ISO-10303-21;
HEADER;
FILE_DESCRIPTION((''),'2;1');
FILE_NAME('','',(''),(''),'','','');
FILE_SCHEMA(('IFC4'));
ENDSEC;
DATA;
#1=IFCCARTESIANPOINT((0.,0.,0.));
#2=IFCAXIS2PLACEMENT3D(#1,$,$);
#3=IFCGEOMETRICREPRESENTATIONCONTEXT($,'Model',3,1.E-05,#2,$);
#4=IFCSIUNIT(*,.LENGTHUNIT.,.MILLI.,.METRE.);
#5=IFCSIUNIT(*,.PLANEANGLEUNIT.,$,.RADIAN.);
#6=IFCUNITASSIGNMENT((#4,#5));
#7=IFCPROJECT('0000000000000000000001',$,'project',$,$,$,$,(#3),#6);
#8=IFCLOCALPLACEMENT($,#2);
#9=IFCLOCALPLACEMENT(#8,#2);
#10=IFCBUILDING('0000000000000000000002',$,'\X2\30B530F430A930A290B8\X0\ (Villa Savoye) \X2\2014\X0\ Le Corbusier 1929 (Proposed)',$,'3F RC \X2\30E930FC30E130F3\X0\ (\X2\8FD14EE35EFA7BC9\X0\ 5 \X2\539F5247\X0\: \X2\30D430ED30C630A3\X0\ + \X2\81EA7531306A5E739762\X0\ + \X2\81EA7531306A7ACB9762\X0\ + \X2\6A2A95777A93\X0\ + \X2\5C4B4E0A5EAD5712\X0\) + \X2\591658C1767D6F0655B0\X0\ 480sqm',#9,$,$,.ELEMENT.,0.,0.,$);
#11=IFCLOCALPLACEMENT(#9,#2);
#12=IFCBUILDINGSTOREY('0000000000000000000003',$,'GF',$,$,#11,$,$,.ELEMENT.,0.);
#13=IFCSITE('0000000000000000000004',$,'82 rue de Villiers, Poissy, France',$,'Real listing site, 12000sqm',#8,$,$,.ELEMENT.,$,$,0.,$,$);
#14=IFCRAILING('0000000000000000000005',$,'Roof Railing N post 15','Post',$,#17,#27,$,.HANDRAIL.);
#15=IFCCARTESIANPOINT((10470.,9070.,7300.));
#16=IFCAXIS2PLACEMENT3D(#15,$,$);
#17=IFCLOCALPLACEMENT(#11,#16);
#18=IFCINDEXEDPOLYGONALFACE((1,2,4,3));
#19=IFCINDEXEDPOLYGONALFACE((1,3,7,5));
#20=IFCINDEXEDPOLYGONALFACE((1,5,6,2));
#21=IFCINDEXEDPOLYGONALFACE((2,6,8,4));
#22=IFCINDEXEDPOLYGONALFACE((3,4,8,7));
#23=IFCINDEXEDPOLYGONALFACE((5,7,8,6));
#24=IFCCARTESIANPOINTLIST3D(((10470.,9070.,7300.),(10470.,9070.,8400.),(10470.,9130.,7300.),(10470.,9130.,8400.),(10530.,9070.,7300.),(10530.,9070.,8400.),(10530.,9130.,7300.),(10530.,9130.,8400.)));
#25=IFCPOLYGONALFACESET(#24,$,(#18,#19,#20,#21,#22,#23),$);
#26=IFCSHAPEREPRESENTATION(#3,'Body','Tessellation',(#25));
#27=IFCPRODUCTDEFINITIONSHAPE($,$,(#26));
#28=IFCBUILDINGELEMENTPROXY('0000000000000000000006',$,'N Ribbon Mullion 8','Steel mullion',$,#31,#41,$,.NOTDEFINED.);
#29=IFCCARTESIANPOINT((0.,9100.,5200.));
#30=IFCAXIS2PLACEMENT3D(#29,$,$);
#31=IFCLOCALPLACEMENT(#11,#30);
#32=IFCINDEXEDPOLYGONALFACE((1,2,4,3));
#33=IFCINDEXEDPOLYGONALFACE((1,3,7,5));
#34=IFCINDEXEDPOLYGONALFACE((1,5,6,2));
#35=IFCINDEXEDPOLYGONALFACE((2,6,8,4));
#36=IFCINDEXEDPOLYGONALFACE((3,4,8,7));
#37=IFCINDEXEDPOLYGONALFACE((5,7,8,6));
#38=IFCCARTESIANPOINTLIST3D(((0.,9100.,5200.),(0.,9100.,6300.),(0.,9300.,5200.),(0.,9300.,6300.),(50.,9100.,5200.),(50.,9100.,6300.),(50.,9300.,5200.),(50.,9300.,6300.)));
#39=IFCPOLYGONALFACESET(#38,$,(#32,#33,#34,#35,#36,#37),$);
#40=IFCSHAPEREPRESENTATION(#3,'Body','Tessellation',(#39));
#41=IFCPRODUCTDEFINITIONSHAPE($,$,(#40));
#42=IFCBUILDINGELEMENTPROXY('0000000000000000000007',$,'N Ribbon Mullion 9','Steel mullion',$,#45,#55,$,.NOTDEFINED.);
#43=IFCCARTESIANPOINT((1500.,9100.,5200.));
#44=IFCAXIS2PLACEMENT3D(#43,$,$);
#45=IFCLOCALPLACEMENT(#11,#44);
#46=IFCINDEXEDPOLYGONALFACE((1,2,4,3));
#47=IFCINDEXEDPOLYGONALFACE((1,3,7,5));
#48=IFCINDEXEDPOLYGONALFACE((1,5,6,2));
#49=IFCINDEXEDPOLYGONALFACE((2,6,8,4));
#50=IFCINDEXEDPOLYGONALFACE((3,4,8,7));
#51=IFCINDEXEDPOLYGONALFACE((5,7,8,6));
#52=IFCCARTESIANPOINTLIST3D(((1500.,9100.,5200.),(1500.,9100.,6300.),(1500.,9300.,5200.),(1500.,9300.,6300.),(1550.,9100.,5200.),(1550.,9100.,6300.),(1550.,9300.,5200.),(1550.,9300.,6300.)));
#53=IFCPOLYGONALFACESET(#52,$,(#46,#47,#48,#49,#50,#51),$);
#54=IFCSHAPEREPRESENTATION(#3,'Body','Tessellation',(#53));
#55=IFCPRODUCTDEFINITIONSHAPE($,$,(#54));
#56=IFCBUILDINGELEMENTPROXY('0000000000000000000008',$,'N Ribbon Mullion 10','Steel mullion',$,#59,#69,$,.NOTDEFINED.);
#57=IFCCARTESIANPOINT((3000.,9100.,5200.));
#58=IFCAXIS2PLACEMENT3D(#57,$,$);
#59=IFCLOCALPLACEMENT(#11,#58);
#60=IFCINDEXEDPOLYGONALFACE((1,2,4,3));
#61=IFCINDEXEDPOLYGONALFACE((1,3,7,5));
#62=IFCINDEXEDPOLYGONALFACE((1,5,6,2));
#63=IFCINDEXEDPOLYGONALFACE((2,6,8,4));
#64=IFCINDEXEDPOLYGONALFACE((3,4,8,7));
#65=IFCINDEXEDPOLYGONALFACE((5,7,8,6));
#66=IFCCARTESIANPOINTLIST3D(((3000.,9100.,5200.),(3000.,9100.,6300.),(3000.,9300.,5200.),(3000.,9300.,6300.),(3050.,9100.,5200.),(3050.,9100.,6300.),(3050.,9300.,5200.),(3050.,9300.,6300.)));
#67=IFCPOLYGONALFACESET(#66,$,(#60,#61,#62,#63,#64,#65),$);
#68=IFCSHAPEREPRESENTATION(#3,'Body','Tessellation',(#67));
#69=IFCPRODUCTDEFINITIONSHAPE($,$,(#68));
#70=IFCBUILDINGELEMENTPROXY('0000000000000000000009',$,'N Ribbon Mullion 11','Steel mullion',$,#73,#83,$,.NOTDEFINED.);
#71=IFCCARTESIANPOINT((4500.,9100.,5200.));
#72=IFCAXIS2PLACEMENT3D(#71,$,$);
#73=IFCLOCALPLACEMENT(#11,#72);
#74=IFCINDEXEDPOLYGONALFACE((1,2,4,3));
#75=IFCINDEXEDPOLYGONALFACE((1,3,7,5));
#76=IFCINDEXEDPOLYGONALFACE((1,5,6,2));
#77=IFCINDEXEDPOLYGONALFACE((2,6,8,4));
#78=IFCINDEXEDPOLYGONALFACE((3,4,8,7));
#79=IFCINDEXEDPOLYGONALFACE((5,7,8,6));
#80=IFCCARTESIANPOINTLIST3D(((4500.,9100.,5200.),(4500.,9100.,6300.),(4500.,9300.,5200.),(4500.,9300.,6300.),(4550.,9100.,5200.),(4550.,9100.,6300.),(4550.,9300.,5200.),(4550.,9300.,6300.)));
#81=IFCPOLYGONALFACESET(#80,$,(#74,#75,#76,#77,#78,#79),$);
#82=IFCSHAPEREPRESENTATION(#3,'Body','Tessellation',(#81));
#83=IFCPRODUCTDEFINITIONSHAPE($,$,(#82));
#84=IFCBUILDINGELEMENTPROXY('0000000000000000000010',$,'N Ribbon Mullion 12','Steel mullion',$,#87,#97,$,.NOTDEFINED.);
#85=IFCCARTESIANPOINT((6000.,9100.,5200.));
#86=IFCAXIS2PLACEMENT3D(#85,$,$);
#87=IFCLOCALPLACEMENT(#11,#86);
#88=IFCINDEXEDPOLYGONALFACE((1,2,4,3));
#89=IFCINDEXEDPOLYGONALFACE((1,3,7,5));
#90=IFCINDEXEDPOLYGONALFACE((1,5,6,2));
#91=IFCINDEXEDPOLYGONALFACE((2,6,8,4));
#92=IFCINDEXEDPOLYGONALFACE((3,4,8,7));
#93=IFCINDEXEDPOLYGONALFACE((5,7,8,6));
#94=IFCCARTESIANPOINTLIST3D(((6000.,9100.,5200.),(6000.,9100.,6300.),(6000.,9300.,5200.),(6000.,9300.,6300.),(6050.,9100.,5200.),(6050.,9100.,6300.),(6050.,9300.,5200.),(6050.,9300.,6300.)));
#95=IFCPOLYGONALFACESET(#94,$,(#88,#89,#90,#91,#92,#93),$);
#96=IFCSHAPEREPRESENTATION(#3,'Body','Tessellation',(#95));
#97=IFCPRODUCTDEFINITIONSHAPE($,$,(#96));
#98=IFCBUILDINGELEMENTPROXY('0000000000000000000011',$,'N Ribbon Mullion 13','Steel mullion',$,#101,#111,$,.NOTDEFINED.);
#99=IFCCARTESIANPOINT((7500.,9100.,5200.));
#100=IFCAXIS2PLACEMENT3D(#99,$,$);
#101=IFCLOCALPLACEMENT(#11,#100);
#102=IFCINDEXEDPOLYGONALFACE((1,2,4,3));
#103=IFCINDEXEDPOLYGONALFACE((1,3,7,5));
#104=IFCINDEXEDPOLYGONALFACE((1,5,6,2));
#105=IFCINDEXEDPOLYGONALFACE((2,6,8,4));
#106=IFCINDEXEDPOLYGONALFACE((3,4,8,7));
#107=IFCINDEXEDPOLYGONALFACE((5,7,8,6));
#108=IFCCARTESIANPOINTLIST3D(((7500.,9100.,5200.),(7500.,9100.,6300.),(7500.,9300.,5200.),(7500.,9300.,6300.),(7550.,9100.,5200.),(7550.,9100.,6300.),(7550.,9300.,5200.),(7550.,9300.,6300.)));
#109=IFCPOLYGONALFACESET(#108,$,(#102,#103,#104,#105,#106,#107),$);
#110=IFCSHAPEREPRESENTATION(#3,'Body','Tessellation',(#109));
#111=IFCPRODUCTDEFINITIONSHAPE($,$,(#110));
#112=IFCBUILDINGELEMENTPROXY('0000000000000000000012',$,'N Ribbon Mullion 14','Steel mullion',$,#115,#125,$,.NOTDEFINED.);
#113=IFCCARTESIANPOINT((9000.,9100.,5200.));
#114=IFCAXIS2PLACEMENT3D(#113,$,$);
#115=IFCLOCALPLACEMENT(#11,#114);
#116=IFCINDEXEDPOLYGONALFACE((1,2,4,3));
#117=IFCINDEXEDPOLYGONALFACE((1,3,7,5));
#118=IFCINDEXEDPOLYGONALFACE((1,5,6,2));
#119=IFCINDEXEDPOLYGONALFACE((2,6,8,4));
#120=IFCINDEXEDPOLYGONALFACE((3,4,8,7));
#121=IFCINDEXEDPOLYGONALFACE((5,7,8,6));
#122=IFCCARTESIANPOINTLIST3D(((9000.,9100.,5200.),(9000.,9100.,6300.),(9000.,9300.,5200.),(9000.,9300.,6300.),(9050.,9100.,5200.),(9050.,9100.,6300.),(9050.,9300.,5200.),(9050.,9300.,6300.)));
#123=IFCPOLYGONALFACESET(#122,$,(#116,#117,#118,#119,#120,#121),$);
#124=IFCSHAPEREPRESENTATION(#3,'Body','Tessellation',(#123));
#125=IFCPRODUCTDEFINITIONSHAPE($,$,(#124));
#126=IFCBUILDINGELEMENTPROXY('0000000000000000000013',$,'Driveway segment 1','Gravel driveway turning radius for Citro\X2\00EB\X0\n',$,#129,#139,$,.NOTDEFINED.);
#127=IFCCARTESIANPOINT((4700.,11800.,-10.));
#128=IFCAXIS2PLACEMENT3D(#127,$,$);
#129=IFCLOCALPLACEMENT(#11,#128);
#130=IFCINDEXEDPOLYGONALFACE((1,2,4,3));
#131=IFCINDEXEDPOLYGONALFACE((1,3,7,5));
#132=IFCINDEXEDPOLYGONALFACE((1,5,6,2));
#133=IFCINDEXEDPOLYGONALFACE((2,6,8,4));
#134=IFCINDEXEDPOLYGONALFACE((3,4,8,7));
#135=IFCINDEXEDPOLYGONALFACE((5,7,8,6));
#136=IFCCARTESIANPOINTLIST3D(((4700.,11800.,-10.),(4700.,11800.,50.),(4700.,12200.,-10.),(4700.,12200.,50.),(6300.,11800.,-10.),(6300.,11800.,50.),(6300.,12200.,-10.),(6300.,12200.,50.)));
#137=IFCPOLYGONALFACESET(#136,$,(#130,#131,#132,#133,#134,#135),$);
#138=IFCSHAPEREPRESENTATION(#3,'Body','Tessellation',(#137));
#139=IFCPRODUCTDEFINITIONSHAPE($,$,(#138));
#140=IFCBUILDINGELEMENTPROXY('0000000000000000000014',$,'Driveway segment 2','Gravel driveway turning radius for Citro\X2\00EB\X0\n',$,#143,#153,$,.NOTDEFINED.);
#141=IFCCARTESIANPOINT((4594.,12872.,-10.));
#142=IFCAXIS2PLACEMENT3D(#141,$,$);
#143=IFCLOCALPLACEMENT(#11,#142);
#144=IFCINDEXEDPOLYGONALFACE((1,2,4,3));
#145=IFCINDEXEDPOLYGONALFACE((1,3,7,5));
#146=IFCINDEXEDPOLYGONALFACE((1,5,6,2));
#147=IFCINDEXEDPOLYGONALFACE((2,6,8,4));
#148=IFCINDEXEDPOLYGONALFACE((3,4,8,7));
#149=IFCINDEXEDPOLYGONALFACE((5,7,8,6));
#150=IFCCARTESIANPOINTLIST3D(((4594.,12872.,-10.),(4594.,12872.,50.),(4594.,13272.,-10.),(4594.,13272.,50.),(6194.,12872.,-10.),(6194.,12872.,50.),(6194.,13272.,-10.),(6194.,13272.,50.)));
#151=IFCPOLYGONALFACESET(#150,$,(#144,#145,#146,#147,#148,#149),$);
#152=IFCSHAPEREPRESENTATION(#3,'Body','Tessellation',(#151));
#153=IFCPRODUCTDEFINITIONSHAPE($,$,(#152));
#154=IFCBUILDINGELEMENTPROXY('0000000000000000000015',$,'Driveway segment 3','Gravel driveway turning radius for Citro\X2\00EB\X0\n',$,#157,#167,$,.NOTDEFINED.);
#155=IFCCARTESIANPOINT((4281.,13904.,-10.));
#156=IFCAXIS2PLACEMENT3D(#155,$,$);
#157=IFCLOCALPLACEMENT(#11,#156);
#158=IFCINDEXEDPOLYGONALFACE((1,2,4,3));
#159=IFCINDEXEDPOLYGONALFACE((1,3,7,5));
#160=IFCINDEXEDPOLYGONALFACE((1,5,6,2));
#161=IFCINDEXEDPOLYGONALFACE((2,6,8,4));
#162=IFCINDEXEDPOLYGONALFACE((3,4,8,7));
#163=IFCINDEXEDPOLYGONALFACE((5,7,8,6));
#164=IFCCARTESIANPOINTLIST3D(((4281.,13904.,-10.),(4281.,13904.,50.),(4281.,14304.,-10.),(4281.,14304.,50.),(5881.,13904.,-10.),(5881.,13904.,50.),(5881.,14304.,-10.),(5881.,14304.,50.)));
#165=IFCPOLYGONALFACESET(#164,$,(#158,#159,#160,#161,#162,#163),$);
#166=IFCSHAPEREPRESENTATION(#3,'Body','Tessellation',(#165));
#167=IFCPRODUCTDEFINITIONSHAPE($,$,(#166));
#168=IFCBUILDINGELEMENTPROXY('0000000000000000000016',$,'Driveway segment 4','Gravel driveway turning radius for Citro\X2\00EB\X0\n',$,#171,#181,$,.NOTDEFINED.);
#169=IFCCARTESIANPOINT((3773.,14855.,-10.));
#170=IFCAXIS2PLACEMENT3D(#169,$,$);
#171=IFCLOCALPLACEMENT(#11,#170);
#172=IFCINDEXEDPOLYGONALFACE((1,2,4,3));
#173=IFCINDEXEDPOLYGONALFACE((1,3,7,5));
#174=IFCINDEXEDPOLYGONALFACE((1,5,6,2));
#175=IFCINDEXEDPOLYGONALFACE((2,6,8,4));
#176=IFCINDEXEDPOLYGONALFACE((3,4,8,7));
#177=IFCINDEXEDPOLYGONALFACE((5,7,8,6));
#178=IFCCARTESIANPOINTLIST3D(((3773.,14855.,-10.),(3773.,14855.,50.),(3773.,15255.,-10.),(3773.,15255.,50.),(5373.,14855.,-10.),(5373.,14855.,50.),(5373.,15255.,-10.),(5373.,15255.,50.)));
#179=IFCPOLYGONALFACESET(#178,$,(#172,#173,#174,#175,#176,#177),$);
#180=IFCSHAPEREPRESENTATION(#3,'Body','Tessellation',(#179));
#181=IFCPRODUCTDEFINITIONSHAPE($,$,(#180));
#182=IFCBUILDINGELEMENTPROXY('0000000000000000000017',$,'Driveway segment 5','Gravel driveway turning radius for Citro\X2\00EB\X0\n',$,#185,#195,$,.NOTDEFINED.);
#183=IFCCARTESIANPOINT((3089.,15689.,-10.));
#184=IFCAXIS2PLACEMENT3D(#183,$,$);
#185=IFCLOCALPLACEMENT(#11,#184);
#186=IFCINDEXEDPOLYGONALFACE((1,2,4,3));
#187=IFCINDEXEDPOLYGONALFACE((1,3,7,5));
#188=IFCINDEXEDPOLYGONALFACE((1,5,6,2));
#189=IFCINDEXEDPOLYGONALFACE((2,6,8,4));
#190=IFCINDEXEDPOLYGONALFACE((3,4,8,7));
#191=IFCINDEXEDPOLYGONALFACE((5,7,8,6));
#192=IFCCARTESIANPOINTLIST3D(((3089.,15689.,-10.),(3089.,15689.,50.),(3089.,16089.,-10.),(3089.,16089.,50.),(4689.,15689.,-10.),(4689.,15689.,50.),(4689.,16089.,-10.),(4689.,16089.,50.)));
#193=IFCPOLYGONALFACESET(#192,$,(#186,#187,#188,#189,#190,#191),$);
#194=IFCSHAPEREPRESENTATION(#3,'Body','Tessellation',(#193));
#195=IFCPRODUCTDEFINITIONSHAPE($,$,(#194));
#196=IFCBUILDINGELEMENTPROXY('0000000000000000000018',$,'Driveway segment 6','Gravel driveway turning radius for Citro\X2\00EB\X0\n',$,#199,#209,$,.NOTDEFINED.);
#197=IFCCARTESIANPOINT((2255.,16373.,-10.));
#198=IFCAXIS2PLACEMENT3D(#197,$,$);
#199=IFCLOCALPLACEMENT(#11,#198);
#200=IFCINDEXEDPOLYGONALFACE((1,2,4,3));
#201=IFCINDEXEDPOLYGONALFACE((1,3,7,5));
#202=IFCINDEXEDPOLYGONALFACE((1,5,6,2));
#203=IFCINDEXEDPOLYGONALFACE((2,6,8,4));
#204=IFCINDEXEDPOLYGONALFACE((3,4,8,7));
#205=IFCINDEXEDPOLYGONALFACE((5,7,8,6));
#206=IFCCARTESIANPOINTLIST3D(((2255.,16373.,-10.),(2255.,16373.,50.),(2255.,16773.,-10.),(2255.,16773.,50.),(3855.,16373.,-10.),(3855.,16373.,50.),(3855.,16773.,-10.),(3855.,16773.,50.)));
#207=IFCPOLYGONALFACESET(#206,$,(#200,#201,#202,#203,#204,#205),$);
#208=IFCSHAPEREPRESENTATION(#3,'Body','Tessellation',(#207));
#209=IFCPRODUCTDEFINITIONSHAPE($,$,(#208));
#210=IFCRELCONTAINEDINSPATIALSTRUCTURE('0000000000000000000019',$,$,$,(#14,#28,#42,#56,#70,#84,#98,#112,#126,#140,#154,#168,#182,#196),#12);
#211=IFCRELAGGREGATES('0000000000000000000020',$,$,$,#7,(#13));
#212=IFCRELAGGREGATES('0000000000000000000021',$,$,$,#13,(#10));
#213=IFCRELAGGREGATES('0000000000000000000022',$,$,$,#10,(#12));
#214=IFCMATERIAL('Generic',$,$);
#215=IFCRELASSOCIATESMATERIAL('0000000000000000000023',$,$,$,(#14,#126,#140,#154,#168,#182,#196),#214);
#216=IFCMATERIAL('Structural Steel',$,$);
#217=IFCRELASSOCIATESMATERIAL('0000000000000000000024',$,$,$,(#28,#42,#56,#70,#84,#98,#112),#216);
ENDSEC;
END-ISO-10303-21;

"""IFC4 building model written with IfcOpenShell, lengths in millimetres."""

from ifc_helpers import new_model, si_unit, frame, frame_2d, origin, place, context, project, spatial, rectangle, extrude, material, element, save


model = new_model("IFC4")

# Units and contexts
model_context = context("Model", 3, precision=1e-05, world=origin())
ifc_project = project(units=[si_unit("LENGTHUNIT", "METRE", prefix="MILLI"), si_unit("PLANEANGLEUNIT", "RADIAN")], contexts=[model_context])

# Site, building, storey
site_placement = place(None, origin())
site = spatial("IfcSite", under=ifc_project, at=site_placement, Name="82 rue de Villiers, Poissy, France", ObjectType="Real listing site, 12000sqm", CompositionType="ELEMENT", RefElevation=0.0)
building_placement = place(site_placement, origin())
building = spatial("IfcBuilding", under=site, at=building_placement, Name="サヴォア邸 (Villa Savoye) — Le Corbusier 1929 (Proposed)", ObjectType="3F RC ラーメン (近代建築 5 原則: ピロティ + 自由な平面 + 自由な立面 + 横長窓 + 屋上庭園) + 外壁白漆喰 480sqm", CompositionType="ELEMENT", ElevationOfRefHeight=0.0, ElevationOfTerrain=0.0)
storey_placement = place(building_placement, origin())
storey = spatial("IfcBuildingStorey", under=building, at=storey_placement, Name="GF", CompositionType="ELEMENT", Elevation=0.0)

# Railing
ifc_material_1 = material(Name="Generic")
for number, where, name in (
    (1, (10470.0, 9070.0, 7300.0), "Roof Railing N post 15"),
):
    element("IfcRailing", number, at=place(storey_placement, frame(where)), inside=storey, material=ifc_material_1, Name=name, Description="Post", PredefinedType="HANDRAIL", context=model_context, shape_type="SweptSolid", body=[
        extrude(rectangle(XDim=60.0, YDim=60.0, at=frame_2d((30.0, 30.0))), frame((10470.0, 9070.0, 7300.0)), (0.0, 0.0, 1.0), 1100.0),
    ])

# Building element proxies
ifc_material_2 = material(Name="Structural Steel")
proxy_1_placement = place(storey_placement, frame((0.0, 9100.0, 5200.0)))
element("IfcBuildingElementProxy", 2, at=proxy_1_placement, inside=storey, material=ifc_material_2, Name="N Ribbon Mullion 8", Description="Steel mullion", PredefinedType="NOTDEFINED", context=model_context, shape_type="SweptSolid", body=[
    extrude(rectangle(XDim=50.0, YDim=200.0, at=frame_2d((25.0, 100.0))), frame((0.0, 9100.0, 5200.0)), (0.0, 0.0, 1.0), 1100.0),
])
proxy_2_placement = place(storey_placement, frame((1500.0, 9100.0, 5200.0)))
element("IfcBuildingElementProxy", 3, at=proxy_2_placement, inside=storey, material=ifc_material_2, Name="N Ribbon Mullion 9", Description="Steel mullion", PredefinedType="NOTDEFINED", context=model_context, shape_type="SweptSolid", body=[
    extrude(rectangle(XDim=50.0, YDim=200.0, at=frame_2d((25.0, 100.0))), frame((1500.0, 9100.0, 5200.0)), (0.0, 0.0, 1.0), 1100.0),
])
proxy_3_placement = place(storey_placement, frame((3000.0, 9100.0, 5200.0)))
element("IfcBuildingElementProxy", 4, at=proxy_3_placement, inside=storey, material=ifc_material_2, Name="N Ribbon Mullion 10", Description="Steel mullion", PredefinedType="NOTDEFINED", context=model_context, shape_type="SweptSolid", body=[
    extrude(rectangle(XDim=50.0, YDim=200.0, at=frame_2d((25.0, 100.0))), frame((3000.0, 9100.0, 5200.0)), (0.0, 0.0, 1.0), 1100.0),
])
proxy_4_placement = place(storey_placement, frame((4500.0, 9100.0, 5200.0)))
element("IfcBuildingElementProxy", 5, at=proxy_4_placement, inside=storey, material=ifc_material_2, Name="N Ribbon Mullion 11", Description="Steel mullion", PredefinedType="NOTDEFINED", context=model_context, shape_type="SweptSolid", body=[
    extrude(rectangle(XDim=50.0, YDim=200.0, at=frame_2d((25.0, 100.0))), frame((4500.0, 9100.0, 5200.0)), (0.0, 0.0, 1.0), 1100.0),
])
proxy_5_placement = place(storey_placement, frame((6000.0, 9100.0, 5200.0)))
element("IfcBuildingElementProxy", 6, at=proxy_5_placement, inside=storey, material=ifc_material_2, Name="N Ribbon Mullion 12", Description="Steel mullion", PredefinedType="NOTDEFINED", context=model_context, shape_type="SweptSolid", body=[
    extrude(rectangle(XDim=50.0, YDim=200.0, at=frame_2d((25.0, 100.0))), frame((6000.0, 9100.0, 5200.0)), (0.0, 0.0, 1.0), 1100.0),
])
proxy_6_placement = place(storey_placement, frame((7500.0, 9100.0, 5200.0)))
element("IfcBuildingElementProxy", 7, at=proxy_6_placement, inside=storey, material=ifc_material_2, Name="N Ribbon Mullion 13", Description="Steel mullion", PredefinedType="NOTDEFINED", context=model_context, shape_type="SweptSolid", body=[
    extrude(rectangle(XDim=50.0, YDim=200.0, at=frame_2d((25.0, 100.0))), frame((7500.0, 9100.0, 5200.0)), (0.0, 0.0, 1.0), 1100.0),
])
proxy_7_placement = place(storey_placement, frame((9000.0, 9100.0, 5200.0)))
element("IfcBuildingElementProxy", 8, at=proxy_7_placement, inside=storey, material=ifc_material_2, Name="N Ribbon Mullion 14", Description="Steel mullion", PredefinedType="NOTDEFINED", context=model_context, shape_type="SweptSolid", body=[
    extrude(rectangle(XDim=50.0, YDim=200.0, at=frame_2d((25.0, 100.0))), frame((9000.0, 9100.0, 5200.0)), (0.0, 0.0, 1.0), 1100.0),
])
proxy_8_placement = place(storey_placement, frame((4700.0, 11800.0, -10.0)))
element("IfcBuildingElementProxy", 9, at=proxy_8_placement, inside=storey, material=ifc_material_1, Name="Driveway segment 1", Description="Gravel driveway turning radius for Citroën", PredefinedType="NOTDEFINED", context=model_context, shape_type="SweptSolid", body=[
    extrude(rectangle(XDim=1600.0, YDim=400.0, at=frame_2d((800.0, 200.0))), frame((4700.0, 11800.0, -10.0)), (0.0, 0.0, 1.0), 60.0),
])
proxy_9_placement = place(storey_placement, frame((4594.0, 12872.0, -10.0)))
element("IfcBuildingElementProxy", 10, at=proxy_9_placement, inside=storey, material=ifc_material_1, Name="Driveway segment 2", Description="Gravel driveway turning radius for Citroën", PredefinedType="NOTDEFINED", context=model_context, shape_type="SweptSolid", body=[
    extrude(rectangle(XDim=1600.0, YDim=400.0, at=frame_2d((800.0, 200.0))), frame((4594.0, 12872.0, -10.0)), (0.0, 0.0, 1.0), 60.0),
])
proxy_10_placement = place(storey_placement, frame((4281.0, 13904.0, -10.0)))
element("IfcBuildingElementProxy", 11, at=proxy_10_placement, inside=storey, material=ifc_material_1, Name="Driveway segment 3", Description="Gravel driveway turning radius for Citroën", PredefinedType="NOTDEFINED", context=model_context, shape_type="SweptSolid", body=[
    extrude(rectangle(XDim=1600.0, YDim=400.0, at=frame_2d((800.0, 200.0))), frame((4281.0, 13904.0, -10.0)), (0.0, 0.0, 1.0), 60.0),
])
proxy_11_placement = place(storey_placement, frame((3773.0, 14855.0, -10.0)))
element("IfcBuildingElementProxy", 12, at=proxy_11_placement, inside=storey, material=ifc_material_1, Name="Driveway segment 4", Description="Gravel driveway turning radius for Citroën", PredefinedType="NOTDEFINED", context=model_context, shape_type="SweptSolid", body=[
    extrude(rectangle(XDim=1600.0, YDim=400.0, at=frame_2d((800.0, 200.0))), frame((3773.0, 14855.0, -10.0)), (0.0, 0.0, 1.0), 60.0),
])
proxy_12_placement = place(storey_placement, frame((3089.0, 15689.0, -10.0)))
element("IfcBuildingElementProxy", 13, at=proxy_12_placement, inside=storey, material=ifc_material_1, Name="Driveway segment 5", Description="Gravel driveway turning radius for Citroën", PredefinedType="NOTDEFINED", context=model_context, shape_type="SweptSolid", body=[
    extrude(rectangle(XDim=1600.0, YDim=400.0, at=frame_2d((800.0, 200.0))), frame((3089.0, 15689.0, -10.0)), (0.0, 0.0, 1.0), 60.0),
])
proxy_13_placement = place(storey_placement, frame((2255.0, 16373.0, -10.0)))
element("IfcBuildingElementProxy", 14, at=proxy_13_placement, inside=storey, material=ifc_material_1, Name="Driveway segment 6", Description="Gravel driveway turning radius for Citroën", PredefinedType="NOTDEFINED", context=model_context, shape_type="SweptSolid", body=[
    extrude(rectangle(XDim=1600.0, YDim=400.0, at=frame_2d((800.0, 200.0))), frame((2255.0, 16373.0, -10.0)), (0.0, 0.0, 1.0), 60.0),
])

save(model, "model.ifc")
